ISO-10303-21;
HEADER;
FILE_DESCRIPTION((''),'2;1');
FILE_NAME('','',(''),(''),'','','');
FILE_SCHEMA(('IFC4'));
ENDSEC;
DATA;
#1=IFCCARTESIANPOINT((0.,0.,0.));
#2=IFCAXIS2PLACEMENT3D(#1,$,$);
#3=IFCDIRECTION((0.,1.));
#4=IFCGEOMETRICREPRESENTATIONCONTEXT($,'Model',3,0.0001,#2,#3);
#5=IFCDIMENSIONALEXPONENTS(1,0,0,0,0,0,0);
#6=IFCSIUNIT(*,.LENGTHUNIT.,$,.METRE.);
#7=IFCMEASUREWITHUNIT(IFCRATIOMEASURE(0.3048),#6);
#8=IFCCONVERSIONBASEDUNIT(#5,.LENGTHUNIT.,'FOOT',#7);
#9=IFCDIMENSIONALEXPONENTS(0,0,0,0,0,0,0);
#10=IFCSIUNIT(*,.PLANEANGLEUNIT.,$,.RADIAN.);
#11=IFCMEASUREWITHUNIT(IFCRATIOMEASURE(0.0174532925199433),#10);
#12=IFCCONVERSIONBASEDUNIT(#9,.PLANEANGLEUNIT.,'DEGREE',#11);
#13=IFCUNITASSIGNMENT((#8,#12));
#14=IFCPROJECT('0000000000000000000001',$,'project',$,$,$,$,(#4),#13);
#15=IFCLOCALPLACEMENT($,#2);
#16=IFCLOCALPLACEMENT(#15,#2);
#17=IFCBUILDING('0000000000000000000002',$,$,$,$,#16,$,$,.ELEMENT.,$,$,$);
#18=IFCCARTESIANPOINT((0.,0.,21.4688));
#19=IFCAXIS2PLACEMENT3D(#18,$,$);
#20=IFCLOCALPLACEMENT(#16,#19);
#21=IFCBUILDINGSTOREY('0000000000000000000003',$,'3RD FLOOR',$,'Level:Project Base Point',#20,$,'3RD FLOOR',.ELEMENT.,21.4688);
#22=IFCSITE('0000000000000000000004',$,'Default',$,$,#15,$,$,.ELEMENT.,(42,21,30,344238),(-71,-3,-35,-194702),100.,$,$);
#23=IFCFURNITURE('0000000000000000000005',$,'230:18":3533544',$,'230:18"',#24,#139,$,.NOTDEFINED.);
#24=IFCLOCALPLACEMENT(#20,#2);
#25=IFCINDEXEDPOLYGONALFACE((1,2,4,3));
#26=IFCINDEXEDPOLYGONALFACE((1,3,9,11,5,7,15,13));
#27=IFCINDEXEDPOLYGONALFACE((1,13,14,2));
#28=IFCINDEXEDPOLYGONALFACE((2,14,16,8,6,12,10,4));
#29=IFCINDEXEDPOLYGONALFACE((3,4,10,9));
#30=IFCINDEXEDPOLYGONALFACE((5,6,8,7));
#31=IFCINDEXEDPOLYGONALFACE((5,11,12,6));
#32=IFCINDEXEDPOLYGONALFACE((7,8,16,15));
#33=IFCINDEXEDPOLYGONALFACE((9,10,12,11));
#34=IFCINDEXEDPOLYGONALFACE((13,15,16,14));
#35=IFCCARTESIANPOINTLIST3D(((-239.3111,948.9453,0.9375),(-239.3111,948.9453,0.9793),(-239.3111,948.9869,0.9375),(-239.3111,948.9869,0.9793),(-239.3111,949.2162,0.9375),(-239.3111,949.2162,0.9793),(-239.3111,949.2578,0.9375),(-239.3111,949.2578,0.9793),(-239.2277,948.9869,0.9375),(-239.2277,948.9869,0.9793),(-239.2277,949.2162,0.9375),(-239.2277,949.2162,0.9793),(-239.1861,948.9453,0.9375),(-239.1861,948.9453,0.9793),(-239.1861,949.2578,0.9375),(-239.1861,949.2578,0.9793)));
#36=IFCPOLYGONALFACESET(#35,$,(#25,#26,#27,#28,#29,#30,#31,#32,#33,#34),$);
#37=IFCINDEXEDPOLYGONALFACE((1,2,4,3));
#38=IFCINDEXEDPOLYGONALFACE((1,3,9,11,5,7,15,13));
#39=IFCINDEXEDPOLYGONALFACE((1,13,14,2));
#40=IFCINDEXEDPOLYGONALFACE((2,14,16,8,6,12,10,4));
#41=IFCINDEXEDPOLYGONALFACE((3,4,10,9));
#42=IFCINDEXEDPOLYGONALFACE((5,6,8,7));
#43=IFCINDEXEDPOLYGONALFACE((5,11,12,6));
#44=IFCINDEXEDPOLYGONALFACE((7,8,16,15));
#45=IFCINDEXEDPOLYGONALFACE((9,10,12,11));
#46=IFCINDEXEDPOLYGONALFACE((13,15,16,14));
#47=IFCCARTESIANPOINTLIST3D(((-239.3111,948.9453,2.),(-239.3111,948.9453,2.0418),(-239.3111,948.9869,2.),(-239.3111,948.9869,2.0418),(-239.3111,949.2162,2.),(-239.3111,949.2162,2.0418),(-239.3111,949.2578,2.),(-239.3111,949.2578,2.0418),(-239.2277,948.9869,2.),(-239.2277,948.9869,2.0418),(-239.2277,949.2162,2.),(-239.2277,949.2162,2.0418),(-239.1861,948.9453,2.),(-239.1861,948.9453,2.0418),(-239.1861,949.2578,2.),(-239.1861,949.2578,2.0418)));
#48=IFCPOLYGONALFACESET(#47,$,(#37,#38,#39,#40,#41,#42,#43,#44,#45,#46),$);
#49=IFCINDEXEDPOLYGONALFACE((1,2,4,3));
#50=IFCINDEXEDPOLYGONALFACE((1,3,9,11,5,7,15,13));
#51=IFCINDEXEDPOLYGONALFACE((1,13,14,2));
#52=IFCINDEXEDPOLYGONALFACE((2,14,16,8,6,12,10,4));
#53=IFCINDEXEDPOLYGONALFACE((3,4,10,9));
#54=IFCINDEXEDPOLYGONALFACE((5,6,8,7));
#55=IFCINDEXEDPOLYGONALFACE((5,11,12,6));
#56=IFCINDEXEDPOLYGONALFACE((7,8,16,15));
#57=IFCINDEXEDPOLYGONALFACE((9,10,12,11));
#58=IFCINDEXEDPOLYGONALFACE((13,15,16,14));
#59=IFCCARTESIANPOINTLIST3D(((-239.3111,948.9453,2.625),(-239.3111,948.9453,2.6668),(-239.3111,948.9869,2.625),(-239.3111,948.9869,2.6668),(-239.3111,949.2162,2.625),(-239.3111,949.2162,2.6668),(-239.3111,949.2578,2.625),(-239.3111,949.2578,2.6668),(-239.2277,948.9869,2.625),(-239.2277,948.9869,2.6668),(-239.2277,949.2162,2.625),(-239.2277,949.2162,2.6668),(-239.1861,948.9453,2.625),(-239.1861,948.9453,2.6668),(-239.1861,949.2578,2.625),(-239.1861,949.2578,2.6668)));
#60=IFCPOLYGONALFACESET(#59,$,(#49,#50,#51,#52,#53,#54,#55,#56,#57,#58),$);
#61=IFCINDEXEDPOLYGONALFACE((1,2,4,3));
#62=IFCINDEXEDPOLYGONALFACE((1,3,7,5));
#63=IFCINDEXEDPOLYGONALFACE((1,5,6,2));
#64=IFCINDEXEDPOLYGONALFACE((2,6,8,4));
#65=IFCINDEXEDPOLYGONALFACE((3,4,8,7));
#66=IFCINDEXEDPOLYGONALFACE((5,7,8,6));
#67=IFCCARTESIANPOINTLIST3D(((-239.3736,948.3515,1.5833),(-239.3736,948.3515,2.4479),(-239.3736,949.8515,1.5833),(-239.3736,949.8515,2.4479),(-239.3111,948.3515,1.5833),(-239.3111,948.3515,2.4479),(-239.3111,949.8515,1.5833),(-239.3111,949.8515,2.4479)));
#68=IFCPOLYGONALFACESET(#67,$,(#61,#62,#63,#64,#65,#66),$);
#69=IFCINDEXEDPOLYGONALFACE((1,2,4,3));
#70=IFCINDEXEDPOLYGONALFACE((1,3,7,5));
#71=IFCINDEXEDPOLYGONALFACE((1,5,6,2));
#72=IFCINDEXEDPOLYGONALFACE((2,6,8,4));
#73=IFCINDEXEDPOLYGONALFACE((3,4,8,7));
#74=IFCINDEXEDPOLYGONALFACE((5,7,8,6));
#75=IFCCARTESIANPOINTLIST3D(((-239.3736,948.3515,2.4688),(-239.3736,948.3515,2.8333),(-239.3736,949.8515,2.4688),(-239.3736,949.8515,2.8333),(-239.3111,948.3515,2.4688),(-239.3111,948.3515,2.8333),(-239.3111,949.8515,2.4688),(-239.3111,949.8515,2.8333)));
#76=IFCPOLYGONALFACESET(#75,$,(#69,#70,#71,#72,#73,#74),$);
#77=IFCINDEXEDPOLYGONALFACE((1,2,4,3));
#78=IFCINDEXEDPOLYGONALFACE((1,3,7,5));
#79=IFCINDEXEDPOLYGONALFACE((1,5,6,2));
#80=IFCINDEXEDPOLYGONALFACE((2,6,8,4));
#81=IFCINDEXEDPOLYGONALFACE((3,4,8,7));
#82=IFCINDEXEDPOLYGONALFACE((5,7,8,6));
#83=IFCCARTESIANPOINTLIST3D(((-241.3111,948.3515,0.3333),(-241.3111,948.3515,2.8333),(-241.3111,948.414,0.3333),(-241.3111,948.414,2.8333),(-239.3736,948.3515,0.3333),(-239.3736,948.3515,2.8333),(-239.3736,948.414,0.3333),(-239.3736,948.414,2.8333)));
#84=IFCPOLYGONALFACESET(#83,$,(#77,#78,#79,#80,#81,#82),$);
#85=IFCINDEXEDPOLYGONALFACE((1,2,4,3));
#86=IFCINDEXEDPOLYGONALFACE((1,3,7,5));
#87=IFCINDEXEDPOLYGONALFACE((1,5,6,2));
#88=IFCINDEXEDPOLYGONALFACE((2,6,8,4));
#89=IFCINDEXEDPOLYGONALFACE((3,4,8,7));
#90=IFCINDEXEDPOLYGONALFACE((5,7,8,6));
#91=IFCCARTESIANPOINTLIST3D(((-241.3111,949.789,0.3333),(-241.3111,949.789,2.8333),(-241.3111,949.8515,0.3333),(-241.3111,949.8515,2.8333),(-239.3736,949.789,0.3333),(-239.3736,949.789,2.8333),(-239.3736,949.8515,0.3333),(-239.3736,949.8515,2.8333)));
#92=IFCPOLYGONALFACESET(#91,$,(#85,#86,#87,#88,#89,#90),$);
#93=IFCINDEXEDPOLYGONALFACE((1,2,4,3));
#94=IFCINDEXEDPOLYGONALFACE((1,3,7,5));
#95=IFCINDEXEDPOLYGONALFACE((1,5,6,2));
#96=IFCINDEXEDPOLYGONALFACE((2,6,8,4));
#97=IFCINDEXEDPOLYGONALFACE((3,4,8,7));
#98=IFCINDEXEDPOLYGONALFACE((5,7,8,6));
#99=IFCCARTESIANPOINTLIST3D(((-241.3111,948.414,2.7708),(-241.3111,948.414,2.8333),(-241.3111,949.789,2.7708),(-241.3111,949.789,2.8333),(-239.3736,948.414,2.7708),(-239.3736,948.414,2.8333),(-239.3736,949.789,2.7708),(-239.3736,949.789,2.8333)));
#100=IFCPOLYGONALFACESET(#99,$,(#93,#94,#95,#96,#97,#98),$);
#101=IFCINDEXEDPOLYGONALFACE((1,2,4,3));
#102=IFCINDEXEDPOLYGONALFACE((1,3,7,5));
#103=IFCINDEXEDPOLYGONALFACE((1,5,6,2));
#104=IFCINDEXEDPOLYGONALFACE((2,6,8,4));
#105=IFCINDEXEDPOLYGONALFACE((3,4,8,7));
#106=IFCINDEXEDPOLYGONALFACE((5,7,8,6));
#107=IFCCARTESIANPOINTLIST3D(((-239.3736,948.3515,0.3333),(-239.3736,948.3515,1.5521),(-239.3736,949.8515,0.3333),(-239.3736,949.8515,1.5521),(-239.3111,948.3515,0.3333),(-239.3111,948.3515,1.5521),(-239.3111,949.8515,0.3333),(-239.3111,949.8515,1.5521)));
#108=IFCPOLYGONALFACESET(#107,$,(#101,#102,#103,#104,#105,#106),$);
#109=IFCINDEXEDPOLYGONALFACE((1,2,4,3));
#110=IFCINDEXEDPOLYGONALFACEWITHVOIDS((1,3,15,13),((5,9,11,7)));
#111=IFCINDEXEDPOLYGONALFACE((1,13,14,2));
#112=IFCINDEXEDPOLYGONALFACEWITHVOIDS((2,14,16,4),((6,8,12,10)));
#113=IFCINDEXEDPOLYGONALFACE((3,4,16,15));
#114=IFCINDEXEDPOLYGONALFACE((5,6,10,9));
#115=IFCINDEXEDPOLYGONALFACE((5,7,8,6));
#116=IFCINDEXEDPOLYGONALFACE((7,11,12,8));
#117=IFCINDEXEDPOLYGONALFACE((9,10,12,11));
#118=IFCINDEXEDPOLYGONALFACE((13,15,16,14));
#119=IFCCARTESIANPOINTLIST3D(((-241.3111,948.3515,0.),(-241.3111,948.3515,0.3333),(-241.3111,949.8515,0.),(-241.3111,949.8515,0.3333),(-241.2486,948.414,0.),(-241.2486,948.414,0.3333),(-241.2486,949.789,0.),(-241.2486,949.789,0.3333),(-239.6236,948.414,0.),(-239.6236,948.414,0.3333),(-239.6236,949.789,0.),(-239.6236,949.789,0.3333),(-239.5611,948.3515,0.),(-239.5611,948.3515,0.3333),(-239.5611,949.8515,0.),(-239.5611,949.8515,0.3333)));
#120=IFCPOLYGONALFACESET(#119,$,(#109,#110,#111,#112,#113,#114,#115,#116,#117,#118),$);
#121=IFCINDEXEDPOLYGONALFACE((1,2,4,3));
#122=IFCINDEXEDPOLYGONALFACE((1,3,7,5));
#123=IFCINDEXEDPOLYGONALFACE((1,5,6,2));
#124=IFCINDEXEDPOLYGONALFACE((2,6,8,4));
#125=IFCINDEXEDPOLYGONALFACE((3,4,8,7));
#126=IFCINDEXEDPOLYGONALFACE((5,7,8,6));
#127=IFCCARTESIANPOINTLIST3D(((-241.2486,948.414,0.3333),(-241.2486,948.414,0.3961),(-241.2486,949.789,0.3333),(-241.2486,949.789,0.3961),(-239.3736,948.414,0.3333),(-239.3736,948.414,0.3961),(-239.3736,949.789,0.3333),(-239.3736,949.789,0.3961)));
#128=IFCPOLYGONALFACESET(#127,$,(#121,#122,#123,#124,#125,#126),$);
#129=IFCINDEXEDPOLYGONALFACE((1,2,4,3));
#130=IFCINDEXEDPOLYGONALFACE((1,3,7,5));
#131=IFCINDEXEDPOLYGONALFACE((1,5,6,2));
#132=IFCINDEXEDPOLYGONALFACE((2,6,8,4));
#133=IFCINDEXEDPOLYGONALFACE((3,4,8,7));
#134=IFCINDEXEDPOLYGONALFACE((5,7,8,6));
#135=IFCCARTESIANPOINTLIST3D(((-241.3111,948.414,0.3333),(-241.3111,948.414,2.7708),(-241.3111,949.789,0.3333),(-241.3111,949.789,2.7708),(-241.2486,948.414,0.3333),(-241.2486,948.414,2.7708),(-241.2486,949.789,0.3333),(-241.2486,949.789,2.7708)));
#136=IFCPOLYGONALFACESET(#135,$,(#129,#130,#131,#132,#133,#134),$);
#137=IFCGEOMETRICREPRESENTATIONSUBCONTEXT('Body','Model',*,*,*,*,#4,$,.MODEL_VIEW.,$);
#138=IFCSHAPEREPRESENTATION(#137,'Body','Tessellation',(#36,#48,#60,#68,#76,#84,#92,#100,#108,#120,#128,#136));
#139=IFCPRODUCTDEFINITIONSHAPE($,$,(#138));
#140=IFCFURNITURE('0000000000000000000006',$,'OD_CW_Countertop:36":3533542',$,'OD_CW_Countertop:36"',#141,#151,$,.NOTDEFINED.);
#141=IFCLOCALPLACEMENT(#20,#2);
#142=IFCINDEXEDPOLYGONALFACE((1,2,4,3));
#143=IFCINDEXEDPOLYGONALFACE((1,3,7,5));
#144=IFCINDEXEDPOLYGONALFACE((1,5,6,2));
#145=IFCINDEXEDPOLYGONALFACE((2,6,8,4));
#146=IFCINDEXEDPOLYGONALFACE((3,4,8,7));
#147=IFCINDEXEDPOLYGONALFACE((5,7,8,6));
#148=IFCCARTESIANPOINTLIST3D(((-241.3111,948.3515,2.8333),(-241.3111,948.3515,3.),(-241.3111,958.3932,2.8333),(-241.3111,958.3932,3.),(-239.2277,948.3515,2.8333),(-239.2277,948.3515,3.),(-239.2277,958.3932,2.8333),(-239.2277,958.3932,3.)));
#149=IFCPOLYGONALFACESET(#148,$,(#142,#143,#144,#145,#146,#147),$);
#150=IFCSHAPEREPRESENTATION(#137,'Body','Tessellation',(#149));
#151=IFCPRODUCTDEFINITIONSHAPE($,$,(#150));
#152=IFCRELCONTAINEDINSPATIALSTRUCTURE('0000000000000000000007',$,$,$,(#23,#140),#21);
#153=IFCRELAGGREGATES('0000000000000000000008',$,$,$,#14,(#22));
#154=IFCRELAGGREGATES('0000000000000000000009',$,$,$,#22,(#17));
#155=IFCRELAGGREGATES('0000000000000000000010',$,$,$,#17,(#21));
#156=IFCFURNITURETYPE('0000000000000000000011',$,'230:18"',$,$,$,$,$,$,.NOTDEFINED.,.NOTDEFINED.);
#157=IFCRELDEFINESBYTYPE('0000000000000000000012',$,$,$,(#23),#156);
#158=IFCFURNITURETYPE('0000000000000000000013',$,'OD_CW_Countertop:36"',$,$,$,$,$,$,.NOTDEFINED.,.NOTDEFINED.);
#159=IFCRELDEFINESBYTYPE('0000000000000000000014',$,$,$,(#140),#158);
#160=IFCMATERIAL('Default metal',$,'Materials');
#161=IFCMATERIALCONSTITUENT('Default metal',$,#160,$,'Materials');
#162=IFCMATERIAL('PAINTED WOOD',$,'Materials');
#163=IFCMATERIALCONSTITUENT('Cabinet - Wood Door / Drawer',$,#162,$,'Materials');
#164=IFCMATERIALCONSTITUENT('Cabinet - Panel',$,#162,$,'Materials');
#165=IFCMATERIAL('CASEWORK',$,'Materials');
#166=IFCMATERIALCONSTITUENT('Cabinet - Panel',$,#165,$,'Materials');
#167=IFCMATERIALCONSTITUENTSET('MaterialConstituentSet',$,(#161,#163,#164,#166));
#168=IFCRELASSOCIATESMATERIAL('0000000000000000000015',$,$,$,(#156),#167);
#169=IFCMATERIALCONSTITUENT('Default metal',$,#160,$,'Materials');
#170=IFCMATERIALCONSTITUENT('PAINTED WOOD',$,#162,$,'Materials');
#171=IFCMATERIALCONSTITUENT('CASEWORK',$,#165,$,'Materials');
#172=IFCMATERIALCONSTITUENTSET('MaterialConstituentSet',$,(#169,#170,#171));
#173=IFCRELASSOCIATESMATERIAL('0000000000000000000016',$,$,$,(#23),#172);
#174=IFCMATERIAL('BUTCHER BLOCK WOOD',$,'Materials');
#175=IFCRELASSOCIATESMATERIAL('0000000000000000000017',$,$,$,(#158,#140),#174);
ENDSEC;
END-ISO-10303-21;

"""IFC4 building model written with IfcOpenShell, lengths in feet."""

from ifc_helpers import new_model, entity, si_unit, converted_unit, direction, frame, frame_2d, origin, origin_2d_with_axis, place, context, subcontext, project, spatial, polyline, rectangle, outline, extrude, source, transform, mapped, material, constituent, constituent_set, type_object, type_shapes, element, save


model = new_model("IFC4")

# Units and contexts
model_context = context("Model", 3, precision=0.0001, world=origin(), true_north=direction((0.0, 1.0)))
body_context = subcontext(model_context, "Body", "Model", "MODEL_VIEW")
ifc_project = project(units=[converted_unit("LENGTHUNIT", "FOOT", entity("IfcRatioMeasure", 0.3048), si_unit("LENGTHUNIT", "METRE"), dimensions=[1, 0, 0, 0, 0, 0, 0]), converted_unit("PLANEANGLEUNIT", "DEGREE", entity("IfcRatioMeasure", 0.0174532925199433), si_unit("PLANEANGLEUNIT", "RADIAN"), dimensions=[0, 0, 0, 0, 0, 0, 0])], contexts=[model_context])

# Site, building, storey
site_placement = place(None, origin())
site = spatial("IfcSite", under=ifc_project, at=site_placement, Name="Default", CompositionType="ELEMENT", RefLatitude=(42, 21, 30, 344238), RefLongitude=(-71, -3, -35, -194702), RefElevation=100.0)
building_placement = place(site_placement, origin())
building = spatial("IfcBuilding", under=site, at=building_placement, CompositionType="ELEMENT")
storey_placement = place(building_placement, frame((0.0, 0.0, 21.4688)))
storey = spatial("IfcBuildingStorey", under=building, at=storey_placement, Name="3RD FLOOR", ObjectType="Level:Project Base Point", LongName="3RD FLOOR", CompositionType="ELEMENT", Elevation=21.4688)

# Furniture
ifc_material_1 = material(Name="Default metal", Category="Materials")
ifc_material_2 = material(Name="PAINTED WOOD", Category="Materials")
ifc_material_3 = material(Name="CASEWORK", Category="Materials")
ifc_constituent_1 = constituent(ifc_material_1, Name="Default metal", Category="Materials")
ifc_constituent_2 = constituent(ifc_material_2, Name="PAINTED WOOD", Category="Materials")
ifc_constituent_3 = constituent(ifc_material_3, Name="CASEWORK", Category="Materials")
ifc_constituent_set_1 = constituent_set(constituents=[ifc_constituent_1, ifc_constituent_2, ifc_constituent_3], Name="MaterialConstituentSet")
ifc_constituent_4 = constituent(ifc_material_1, Name="Default metal", Category="Materials")
ifc_constituent_5 = constituent(ifc_material_2, Name="Cabinet - Wood Door / Drawer", Category="Materials")
ifc_constituent_6 = constituent(ifc_material_2, Name="Cabinet - Panel", Category="Materials")
ifc_constituent_7 = constituent(ifc_material_3, Name="Cabinet - Panel", Category="Materials")
ifc_constituent_set_2 = constituent_set(constituents=[ifc_constituent_4, ifc_constituent_5, ifc_constituent_6, ifc_constituent_7], Name="MaterialConstituentSet")
furniture_type_1 = type_object("IfcFurnitureType", Name="230:18\"", AssemblyPlace="NOTDEFINED", PredefinedType="NOTDEFINED", material=ifc_constituent_set_2)
shared_shape_1 = source(origin(), body_context, "Body", "SweptSolid", [
    extrude(outline(polyline([(-0.0521, -0.1562), (0.0729, -0.1562), (0.0729, 0.1562), (-0.0521, 0.1562), (-0.0521, 0.1146), (0.0313, 0.1146), (0.0313, -0.1146), (-0.0521, -0.1146), (-0.0521, -0.1562)])), frame((0.0615, -2.0521, 0.9375), z_axis=(0.0, 0.0, 1.0), x_axis=(0.0, -1.0, 0.0)), (0.0, 0.0, 1.0), 0.0418),
    extrude(outline(polyline([(-0.0521, -0.1562), (0.0729, -0.1562), (0.0729, 0.1562), (-0.0521, 0.1562), (-0.0521, 0.1146), (0.0313, 0.1146), (0.0313, -0.1146), (-0.0521, -0.1146), (-0.0521, -0.1562)])), frame((0.0615, -2.0521, 2.0), z_axis=(0.0, 0.0, 1.0), x_axis=(0.0, -1.0, 0.0)), (0.0, 0.0, 1.0), 0.0418),
    extrude(outline(polyline([(-0.0521, -0.1562), (0.0729, -0.1562), (0.0729, 0.1562), (-0.0521, 0.1562), (-0.0521, 0.1146), (0.0313, 0.1146), (0.0313, -0.1146), (-0.0521, -0.1146), (-0.0521, -0.1562)])), frame((0.0615, -2.0521, 2.625), z_axis=(0.0, 0.0, 1.0), x_axis=(0.0, -1.0, 0.0)), (0.0, 0.0, 1.0), 0.0418),
    extrude(rectangle(XDim=0.0625, YDim=1.5, at=frame_2d((0.0, 0.0), x_axis=(1.0, 0.0))), frame((0.0615, -1.9688, 1.5833), z_axis=(0.0, 0.0, 1.0), x_axis=(0.0, 1.0, 0.0)), (0.0, 0.0, 1.0), 0.8646),
    extrude(rectangle(XDim=0.0625, YDim=1.5, at=frame_2d((0.0, 0.0), x_axis=(1.0, 0.0))), frame((0.0615, -1.9688, 2.4688), z_axis=(0.0, 0.0, 1.0), x_axis=(0.0, 1.0, 0.0)), (0.0, 0.0, 1.0), 0.3646),
    extrude(rectangle(XDim=0.0625, YDim=1.9375, at=frame_2d((0.0, 0.0), x_axis=(1.0, 0.0))), frame((-0.6573, -0.9687, 0.3333)), (0.0, 0.0, 1.0), 2.5),
    extrude(rectangle(XDim=0.0625, YDim=1.9375, at=frame_2d((0.0, 0.0), x_axis=(1.0, 0.0))), frame((0.7802, -0.9687, 0.3333)), (0.0, 0.0, 1.0), 2.5),
    extrude(rectangle(XDim=1.375, YDim=1.9375, at=origin_2d_with_axis()), frame((0.0615, -0.9687, 2.7708), z_axis=(0.0, 0.0, 1.0), x_axis=(-1.0, 0.0, 0.0)), (0.0, 0.0, 1.0), 0.0625),
    extrude(rectangle(XDim=0.0625, YDim=1.5, at=frame_2d((0.0, 0.0), x_axis=(1.0, 0.0))), frame((0.0615, -1.9688, 0.3333), z_axis=(0.0, 0.0, 1.0), x_axis=(0.0, 1.0, 0.0)), (0.0, 0.0, 1.0), 1.2187),
    extrude(outline(polyline([(-0.75, -0.875), (0.75, -0.875), (0.75, 0.875), (-0.75, 0.875), (-0.75, -0.875)]), holes=[polyline([(-0.6875, -0.8125), (-0.6875, 0.8125), (0.6875, 0.8125), (0.6875, -0.8125), (-0.6875, -0.8125)])]), frame((0.0615, -0.875, 0.0)), (0.0, 0.0, 1.0), 0.3333),
    extrude(rectangle(XDim=1.375, YDim=1.875, at=frame_2d((0.0, 0.0), x_axis=(1.0, 0.0))), frame((0.0615, -1.0, 0.3333), z_axis=(0.0, 0.0, 1.0), x_axis=(-1.0, 0.0, 0.0)), (0.0, 0.0, 1.0), 0.0627),
    extrude(rectangle(XDim=0.0625, YDim=1.375, at=origin_2d_with_axis()), frame((0.0615, -0.0312, 0.3333), z_axis=(0.0, 0.0, 1.0), x_axis=(0.0, 1.0, 0.0)), (0.0, 0.0, 1.0), 2.4375),
])
type_shapes(furniture_type_1, [shared_shape_1])
furniture_1_placement = place(storey_placement, frame((-241.3111, 949.04, 0.0), z_axis=(0.0, 0.0, 1.0), x_axis=(0.0, 1.0, 0.0)))
element("IfcFurniture", 1, at=furniture_1_placement, inside=storey, type_object=furniture_type_1, material=ifc_constituent_set_1, Name="230:18\":3533544", ObjectType="230:18\"", PredefinedType="NOTDEFINED", context=body_context, shape_type="MappedRepresentation", body=[
    mapped(shared_shape_1, transform((0.0, 0.0, 0.0), scale=1.0)),
])
ifc_material_4 = material(Name="BUTCHER BLOCK WOOD", Category="Materials")
furniture_type_2 = type_object("IfcFurnitureType", Name="OD_CW_Countertop:36\"", AssemblyPlace="NOTDEFINED", PredefinedType="NOTDEFINED", material=ifc_material_4)
shared_shape_2 = source(origin(), body_context, "Body", "SweptSolid", [
    extrude(rectangle(XDim=10.0417, YDim=2.0833, at=origin_2d_with_axis()), frame((5.0208, 1.0417, 0.0)), (0.0, 0.0, 1.0), 0.1667),
])
type_shapes(furniture_type_2, [shared_shape_2])
furniture_2_placement = place(storey_placement, frame((-241.3111, 958.3932, 2.8333), z_axis=(0.0, 0.0, 1.0), x_axis=(0.0, -1.0, 0.0)))
element("IfcFurniture", 2, at=furniture_2_placement, inside=storey, type_object=furniture_type_2, material=ifc_material_4, Name="OD_CW_Countertop:36\":3533542", ObjectType="OD_CW_Countertop:36\"", PredefinedType="NOTDEFINED", context=body_context, shape_type="MappedRepresentation", body=[
    mapped(shared_shape_2, transform((0.0, 0.0, 0.0), scale=1.0)),
])

save(model, "model.ifc")
